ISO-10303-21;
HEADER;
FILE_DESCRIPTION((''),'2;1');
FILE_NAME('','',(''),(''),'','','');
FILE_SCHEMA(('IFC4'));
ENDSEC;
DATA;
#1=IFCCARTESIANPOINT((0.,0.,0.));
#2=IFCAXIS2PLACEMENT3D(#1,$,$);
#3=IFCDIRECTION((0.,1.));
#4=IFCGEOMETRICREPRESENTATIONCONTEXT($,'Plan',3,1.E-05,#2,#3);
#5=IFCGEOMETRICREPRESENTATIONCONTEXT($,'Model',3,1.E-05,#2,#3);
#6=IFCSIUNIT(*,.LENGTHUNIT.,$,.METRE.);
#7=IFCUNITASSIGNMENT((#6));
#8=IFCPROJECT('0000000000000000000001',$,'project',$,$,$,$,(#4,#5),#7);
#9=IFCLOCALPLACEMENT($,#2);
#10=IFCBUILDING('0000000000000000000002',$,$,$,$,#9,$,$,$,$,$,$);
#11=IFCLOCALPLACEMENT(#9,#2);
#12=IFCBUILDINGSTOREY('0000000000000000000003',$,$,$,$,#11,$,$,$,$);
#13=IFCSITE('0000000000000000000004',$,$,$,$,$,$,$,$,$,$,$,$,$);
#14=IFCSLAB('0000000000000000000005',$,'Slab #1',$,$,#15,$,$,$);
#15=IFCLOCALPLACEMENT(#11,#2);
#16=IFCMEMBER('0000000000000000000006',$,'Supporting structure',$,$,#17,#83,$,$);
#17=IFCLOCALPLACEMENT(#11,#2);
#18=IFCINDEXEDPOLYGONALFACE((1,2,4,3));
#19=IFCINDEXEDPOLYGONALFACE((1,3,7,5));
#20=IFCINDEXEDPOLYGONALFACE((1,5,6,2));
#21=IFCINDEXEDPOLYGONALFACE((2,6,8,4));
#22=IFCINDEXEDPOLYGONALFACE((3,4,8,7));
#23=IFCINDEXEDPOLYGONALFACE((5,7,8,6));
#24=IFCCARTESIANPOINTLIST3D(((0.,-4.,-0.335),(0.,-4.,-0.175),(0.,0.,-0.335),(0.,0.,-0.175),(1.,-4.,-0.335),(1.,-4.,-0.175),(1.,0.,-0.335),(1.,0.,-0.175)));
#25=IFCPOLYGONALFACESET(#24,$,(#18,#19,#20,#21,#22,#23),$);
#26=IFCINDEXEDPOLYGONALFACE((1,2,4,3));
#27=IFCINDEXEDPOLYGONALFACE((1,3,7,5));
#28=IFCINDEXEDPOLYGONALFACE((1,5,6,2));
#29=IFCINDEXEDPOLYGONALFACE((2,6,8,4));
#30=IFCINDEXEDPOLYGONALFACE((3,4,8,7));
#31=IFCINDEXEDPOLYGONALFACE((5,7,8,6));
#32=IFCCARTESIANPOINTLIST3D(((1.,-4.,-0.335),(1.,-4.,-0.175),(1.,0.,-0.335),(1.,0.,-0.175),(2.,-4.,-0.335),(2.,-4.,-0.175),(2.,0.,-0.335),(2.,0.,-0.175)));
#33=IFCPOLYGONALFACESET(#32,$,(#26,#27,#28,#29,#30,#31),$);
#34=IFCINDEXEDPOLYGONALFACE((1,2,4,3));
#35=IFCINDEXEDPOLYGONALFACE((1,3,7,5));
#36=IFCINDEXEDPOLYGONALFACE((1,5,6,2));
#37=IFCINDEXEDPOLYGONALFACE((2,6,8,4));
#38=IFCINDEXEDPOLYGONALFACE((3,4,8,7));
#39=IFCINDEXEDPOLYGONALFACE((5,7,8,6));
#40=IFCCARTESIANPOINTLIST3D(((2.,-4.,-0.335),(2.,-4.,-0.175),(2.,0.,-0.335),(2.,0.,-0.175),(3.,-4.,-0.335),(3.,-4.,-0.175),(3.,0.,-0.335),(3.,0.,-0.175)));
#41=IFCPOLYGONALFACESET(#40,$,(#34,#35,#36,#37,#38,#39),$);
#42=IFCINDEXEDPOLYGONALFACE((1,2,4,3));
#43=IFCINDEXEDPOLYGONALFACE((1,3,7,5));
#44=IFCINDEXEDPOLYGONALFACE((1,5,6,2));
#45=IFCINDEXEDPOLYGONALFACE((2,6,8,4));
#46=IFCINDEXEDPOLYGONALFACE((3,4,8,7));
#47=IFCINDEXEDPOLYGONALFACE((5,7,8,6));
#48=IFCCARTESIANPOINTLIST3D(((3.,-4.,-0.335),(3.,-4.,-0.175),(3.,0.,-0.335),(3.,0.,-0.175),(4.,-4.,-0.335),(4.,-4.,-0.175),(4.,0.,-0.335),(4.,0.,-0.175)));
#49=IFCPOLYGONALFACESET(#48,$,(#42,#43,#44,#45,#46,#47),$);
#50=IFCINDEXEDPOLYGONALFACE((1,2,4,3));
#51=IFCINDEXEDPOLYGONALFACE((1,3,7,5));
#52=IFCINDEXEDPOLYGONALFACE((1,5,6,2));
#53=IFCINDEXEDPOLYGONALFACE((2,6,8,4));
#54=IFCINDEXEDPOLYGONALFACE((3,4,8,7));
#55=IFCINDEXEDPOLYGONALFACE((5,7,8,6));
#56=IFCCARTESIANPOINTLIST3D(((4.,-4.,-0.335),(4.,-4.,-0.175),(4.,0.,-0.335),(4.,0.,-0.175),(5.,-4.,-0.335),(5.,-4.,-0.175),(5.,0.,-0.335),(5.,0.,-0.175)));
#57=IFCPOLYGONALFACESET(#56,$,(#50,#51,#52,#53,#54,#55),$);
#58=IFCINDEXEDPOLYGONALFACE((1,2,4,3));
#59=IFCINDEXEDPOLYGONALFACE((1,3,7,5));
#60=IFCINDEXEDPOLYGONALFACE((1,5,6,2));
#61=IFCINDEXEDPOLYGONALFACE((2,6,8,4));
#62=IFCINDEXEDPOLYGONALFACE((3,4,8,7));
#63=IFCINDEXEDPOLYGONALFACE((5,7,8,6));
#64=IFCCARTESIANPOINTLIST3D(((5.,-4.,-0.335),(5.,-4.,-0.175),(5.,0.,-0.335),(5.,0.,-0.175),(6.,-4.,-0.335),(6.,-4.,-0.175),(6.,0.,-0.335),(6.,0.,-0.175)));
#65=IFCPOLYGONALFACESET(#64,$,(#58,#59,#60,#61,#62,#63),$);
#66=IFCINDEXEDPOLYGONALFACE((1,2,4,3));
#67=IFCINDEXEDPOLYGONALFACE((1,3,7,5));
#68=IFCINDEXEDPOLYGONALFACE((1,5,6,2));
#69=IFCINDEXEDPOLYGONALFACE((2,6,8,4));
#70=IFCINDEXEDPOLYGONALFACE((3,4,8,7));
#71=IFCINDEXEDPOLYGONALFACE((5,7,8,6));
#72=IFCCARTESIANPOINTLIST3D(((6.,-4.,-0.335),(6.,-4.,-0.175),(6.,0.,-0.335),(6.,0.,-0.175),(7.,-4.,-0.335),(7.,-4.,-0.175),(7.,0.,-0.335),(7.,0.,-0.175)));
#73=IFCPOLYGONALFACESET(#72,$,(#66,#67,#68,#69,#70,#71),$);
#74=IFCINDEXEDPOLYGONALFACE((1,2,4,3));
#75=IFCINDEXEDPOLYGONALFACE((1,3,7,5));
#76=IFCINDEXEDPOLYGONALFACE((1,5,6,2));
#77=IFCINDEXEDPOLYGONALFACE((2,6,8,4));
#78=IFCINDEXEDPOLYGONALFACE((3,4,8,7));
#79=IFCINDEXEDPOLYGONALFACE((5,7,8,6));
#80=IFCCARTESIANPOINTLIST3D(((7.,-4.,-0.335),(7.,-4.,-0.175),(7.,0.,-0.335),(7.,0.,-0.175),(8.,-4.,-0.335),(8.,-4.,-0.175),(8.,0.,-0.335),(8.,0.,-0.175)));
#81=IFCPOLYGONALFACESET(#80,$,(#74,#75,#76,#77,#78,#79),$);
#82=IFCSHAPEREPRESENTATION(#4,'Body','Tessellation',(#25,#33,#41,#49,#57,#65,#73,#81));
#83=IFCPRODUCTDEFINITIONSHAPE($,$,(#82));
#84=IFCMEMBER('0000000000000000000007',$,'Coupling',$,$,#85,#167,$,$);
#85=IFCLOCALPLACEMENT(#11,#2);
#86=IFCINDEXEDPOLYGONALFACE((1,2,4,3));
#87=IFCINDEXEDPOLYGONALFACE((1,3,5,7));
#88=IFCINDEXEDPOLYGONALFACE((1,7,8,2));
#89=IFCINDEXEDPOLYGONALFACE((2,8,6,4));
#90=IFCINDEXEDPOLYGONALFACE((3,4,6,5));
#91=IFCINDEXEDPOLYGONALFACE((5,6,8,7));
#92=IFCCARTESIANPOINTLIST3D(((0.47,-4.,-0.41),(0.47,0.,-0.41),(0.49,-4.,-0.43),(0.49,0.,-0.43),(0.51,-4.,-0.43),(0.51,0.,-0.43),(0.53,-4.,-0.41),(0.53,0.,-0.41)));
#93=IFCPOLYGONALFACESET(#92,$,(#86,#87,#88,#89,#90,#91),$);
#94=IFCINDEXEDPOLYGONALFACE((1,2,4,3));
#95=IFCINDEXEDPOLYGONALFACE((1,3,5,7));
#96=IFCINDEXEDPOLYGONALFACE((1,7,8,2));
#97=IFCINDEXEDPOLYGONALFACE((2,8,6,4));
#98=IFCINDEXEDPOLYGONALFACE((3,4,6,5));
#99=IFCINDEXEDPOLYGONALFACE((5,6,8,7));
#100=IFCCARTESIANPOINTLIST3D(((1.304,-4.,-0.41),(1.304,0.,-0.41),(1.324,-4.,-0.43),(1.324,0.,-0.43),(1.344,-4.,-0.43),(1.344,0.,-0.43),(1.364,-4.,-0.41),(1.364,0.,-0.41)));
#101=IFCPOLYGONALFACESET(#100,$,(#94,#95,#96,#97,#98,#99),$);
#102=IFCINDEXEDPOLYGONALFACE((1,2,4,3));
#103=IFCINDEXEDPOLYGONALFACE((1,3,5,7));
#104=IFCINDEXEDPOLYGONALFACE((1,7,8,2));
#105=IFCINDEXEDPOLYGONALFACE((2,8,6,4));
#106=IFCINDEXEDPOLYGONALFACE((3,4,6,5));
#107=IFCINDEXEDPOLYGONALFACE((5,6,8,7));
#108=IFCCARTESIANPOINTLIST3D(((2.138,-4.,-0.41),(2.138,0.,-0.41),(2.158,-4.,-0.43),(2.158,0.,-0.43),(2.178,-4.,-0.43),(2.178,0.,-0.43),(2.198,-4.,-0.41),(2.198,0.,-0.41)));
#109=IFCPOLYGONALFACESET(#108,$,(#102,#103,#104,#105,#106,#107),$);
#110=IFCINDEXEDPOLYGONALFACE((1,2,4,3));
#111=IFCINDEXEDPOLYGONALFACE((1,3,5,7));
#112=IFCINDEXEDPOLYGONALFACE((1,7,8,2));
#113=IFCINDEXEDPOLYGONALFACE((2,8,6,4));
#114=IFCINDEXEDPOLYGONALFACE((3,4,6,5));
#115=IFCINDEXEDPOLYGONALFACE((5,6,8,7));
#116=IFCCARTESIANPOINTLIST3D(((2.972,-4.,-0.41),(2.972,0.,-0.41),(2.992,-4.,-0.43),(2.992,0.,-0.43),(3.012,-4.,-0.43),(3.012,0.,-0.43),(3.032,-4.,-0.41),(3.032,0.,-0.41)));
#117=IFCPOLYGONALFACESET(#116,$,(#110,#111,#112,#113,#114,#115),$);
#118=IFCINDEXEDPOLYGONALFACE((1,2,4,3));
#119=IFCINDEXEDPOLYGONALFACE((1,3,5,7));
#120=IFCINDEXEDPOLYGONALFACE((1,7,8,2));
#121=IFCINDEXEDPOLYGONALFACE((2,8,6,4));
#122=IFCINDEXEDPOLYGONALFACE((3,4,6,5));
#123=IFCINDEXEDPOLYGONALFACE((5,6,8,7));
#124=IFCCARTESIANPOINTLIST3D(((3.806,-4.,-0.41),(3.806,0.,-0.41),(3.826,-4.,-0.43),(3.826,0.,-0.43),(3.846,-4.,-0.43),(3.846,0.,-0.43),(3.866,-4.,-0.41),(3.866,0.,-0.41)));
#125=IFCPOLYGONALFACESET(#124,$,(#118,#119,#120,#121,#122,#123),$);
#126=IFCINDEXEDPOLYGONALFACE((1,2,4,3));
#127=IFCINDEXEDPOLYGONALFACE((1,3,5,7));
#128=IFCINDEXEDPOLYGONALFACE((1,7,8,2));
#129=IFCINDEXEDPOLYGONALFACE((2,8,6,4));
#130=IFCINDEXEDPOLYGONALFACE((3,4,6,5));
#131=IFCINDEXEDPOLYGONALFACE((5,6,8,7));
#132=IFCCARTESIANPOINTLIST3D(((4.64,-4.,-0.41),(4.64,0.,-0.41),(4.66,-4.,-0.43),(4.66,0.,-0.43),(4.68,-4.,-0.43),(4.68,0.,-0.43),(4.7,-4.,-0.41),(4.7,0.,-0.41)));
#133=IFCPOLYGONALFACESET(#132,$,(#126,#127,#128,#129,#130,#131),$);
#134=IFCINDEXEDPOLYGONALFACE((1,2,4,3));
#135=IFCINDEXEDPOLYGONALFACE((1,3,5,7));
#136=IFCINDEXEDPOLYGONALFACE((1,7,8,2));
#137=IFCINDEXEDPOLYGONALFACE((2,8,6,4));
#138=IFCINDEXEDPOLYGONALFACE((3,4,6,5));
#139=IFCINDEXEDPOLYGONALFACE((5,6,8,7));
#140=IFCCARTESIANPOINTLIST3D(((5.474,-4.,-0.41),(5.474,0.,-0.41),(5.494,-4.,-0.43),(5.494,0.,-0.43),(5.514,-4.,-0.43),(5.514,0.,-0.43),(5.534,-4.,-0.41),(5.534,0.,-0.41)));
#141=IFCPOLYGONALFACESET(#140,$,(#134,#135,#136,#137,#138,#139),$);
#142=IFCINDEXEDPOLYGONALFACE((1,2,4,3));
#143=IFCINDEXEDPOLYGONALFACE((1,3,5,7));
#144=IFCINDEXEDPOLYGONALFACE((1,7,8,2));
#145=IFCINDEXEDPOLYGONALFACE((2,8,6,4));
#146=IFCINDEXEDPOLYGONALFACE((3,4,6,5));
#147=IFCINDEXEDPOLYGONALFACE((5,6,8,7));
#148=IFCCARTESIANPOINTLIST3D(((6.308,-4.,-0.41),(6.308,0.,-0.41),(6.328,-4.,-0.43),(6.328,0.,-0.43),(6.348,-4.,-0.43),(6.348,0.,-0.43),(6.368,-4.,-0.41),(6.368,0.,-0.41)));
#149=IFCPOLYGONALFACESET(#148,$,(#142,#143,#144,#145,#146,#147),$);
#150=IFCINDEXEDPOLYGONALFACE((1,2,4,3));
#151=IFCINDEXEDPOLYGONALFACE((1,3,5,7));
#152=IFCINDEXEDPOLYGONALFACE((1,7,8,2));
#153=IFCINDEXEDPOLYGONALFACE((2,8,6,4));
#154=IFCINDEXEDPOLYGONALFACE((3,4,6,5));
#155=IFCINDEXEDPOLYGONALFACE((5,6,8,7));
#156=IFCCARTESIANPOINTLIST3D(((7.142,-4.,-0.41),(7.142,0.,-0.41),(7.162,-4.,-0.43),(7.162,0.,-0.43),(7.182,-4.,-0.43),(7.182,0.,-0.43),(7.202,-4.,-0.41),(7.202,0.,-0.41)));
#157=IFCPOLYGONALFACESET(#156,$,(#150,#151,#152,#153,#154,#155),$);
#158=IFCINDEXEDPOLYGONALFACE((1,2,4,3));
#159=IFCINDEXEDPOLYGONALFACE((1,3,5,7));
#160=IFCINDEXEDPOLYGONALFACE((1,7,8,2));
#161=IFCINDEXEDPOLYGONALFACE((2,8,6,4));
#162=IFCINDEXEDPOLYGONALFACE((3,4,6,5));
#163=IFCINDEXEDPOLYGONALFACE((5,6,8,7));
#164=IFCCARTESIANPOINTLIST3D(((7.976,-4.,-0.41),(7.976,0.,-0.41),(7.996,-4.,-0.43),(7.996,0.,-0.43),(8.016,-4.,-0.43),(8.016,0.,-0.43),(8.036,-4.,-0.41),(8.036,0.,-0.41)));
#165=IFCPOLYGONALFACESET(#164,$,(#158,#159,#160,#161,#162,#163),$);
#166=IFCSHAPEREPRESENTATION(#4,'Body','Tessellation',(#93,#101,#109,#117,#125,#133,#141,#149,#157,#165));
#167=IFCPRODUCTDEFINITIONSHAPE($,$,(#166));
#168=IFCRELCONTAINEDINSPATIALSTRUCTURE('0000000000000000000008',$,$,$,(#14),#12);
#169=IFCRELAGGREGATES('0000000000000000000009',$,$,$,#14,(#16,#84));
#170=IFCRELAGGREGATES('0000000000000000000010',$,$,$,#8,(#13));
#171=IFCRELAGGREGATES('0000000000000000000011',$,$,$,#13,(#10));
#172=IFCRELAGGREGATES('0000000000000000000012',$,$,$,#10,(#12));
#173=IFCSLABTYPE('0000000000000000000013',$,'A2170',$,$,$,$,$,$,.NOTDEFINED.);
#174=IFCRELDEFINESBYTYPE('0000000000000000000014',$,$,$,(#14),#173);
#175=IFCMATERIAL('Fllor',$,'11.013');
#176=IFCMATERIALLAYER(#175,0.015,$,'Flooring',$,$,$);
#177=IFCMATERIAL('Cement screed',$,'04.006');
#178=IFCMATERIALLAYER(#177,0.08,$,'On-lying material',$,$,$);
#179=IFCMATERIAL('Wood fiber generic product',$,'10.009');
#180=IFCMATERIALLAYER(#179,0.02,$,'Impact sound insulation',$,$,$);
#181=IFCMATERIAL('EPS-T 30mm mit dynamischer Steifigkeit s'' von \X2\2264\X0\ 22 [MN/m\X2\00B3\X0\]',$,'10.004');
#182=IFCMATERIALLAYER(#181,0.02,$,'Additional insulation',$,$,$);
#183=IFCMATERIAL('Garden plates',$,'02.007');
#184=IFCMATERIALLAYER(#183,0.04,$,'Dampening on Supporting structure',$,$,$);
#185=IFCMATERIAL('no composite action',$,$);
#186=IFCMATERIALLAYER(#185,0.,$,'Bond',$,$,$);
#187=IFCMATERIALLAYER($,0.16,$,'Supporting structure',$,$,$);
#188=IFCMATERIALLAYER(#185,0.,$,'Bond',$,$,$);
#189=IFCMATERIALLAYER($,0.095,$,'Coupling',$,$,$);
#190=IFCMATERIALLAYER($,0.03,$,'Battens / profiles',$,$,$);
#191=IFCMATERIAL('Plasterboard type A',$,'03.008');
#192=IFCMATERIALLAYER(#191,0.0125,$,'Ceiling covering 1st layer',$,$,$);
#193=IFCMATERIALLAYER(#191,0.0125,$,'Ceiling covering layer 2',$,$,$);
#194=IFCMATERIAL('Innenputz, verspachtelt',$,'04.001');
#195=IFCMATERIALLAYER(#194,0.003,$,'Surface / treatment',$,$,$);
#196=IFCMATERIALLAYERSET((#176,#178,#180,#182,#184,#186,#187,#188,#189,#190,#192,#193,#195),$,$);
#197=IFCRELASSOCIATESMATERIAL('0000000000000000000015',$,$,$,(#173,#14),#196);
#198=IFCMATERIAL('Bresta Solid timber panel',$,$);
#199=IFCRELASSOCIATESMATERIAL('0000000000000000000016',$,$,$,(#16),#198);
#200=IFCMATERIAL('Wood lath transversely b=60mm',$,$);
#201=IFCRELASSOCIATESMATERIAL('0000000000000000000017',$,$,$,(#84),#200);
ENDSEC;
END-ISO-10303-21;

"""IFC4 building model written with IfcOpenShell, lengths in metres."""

from ifc_helpers import new_model, si_unit, direction, frame, frame_2d, origin, place, context, project, spatial, polyline, rectangle, outline, extrude, material, layer, layer_set, type_object, element, aggregate, save


model = new_model("IFC4")

# Units and contexts
plan_context = context("Plan", 3, precision=1e-05, world=origin(), true_north=direction((0.0, 1.0)))
model_context = context("Model", 3, precision=1e-05, world=origin(), true_north=direction((0.0, 1.0)))
ifc_project = project(units=[si_unit("LENGTHUNIT", "METRE")], contexts=[plan_context, model_context])

# Site, building, storey
site = spatial("IfcSite", under=ifc_project)
building_placement = place(None, origin())
building = spatial("IfcBuilding", under=site, at=building_placement)
storey_placement = place(building_placement, origin())
storey = spatial("IfcBuildingStorey", under=building, at=storey_placement)

# Slab, members
ifc_material_1 = material(Name="Fllor", Category="11.013")
ifc_layer_1 = layer(ifc_material_1, 0.015, Name="Flooring")
ifc_material_2 = material(Name="Cement screed", Category="04.006")
ifc_layer_2 = layer(ifc_material_2, 0.08, Name="On-lying material")
ifc_material_3 = material(Name="Wood fiber generic product", Category="10.009")
ifc_layer_3 = layer(ifc_material_3, 0.02, Name="Impact sound insulation")
ifc_material_4 = material(Name="EPS-T 30mm mit dynamischer Steifigkeit s' von ≤ 22 [MN/m³]", Category="10.004")
ifc_layer_4 = layer(ifc_material_4, 0.02, Name="Additional insulation")
ifc_material_5 = material(Name="Garden plates", Category="02.007")
ifc_layer_5 = layer(ifc_material_5, 0.04, Name="Dampening on Supporting structure")
ifc_material_6 = material(Name="no composite action")
ifc_layer_6 = layer(ifc_material_6, 0.0, Name="Bond")
ifc_layer_7 = layer(None, 0.16, Name="Supporting structure")
ifc_layer_8 = layer(ifc_material_6, 0.0, Name="Bond")
ifc_layer_9 = layer(None, 0.095, Name="Coupling")
ifc_layer_10 = layer(None, 0.03, Name="Battens / profiles")
ifc_material_7 = material(Name="Plasterboard type A", Category="03.008")
ifc_layer_11 = layer(ifc_material_7, 0.0125, Name="Ceiling covering 1st layer")
ifc_layer_12 = layer(ifc_material_7, 0.0125, Name="Ceiling covering layer 2")
ifc_material_8 = material(Name="Innenputz, verspachtelt", Category="04.001")
ifc_layer_13 = layer(ifc_material_8, 0.003, Name="Surface / treatment")
ifc_layer_set = layer_set([ifc_layer_1, ifc_layer_2, ifc_layer_3, ifc_layer_4, ifc_layer_5, ifc_layer_6, ifc_layer_7, ifc_layer_8, ifc_layer_9, ifc_layer_10, ifc_layer_11, ifc_layer_12, ifc_layer_13])
slab_type = type_object("IfcSlabType", Name="A2170", PredefinedType="NOTDEFINED", material=ifc_layer_set)
slab_placement = place(None, frame((0.0, 0.0, 0.0), z_axis=(0.0, 0.0, -1.0), x_axis=(1.0, 0.0, 0.0)))
slab = element("IfcSlab", 1, at=slab_placement, inside=storey, type_object=slab_type, material=ifc_layer_set, Name="Slab #1")
ifc_material_9 = material(Name="Bresta Solid timber panel")
member_1_placement = place(slab_placement, origin())
member_1 = element("IfcMember", 2, at=member_1_placement, material=ifc_material_9, Name="Supporting structure", context=plan_context, shape_type="SweptSolid", body=[
    extrude(rectangle(XDim=1.0, YDim=0.16, at=frame_2d((0.5, 0.08), x_axis=(1.0, 0.0))), frame((0.0, 4.0, 0.175), z_axis=(0.0, -1.0, 0.0), x_axis=(1.0, 0.0, 0.0)), (0.0, 0.0, 1.0), 4.0),
    extrude(rectangle(XDim=1.0, YDim=0.16, at=frame_2d((0.5, 0.08), x_axis=(1.0, 0.0))), frame((1.0, 4.0, 0.175), z_axis=(0.0, -1.0, 0.0), x_axis=(1.0, 0.0, 0.0)), (0.0, 0.0, 1.0), 4.0),
    extrude(rectangle(XDim=1.0, YDim=0.16, at=frame_2d((0.5, 0.08), x_axis=(1.0, 0.0))), frame((2.0, 4.0, 0.175), z_axis=(0.0, -1.0, 0.0), x_axis=(1.0, 0.0, 0.0)), (0.0, 0.0, 1.0), 4.0),
    extrude(rectangle(XDim=1.0, YDim=0.16, at=frame_2d((0.5, 0.08), x_axis=(1.0, 0.0))), frame((3.0, 4.0, 0.175), z_axis=(0.0, -1.0, 0.0), x_axis=(1.0, 0.0, 0.0)), (0.0, 0.0, 1.0), 4.0),
    extrude(rectangle(XDim=1.0, YDim=0.16, at=frame_2d((0.5, 0.08), x_axis=(1.0, 0.0))), frame((4.0, 4.0, 0.175), z_axis=(0.0, -1.0, 0.0), x_axis=(1.0, 0.0, 0.0)), (0.0, 0.0, 1.0), 4.0),
    extrude(rectangle(XDim=1.0, YDim=0.16, at=frame_2d((0.5, 0.08), x_axis=(1.0, 0.0))), frame((5.0, 4.0, 0.175), z_axis=(0.0, -1.0, 0.0), x_axis=(1.0, 0.0, 0.0)), (0.0, 0.0, 1.0), 4.0),
    extrude(rectangle(XDim=1.0, YDim=0.16, at=frame_2d((0.5, 0.08), x_axis=(1.0, 0.0))), frame((6.0, 4.0, 0.175), z_axis=(0.0, -1.0, 0.0), x_axis=(1.0, 0.0, 0.0)), (0.0, 0.0, 1.0), 4.0),
    extrude(rectangle(XDim=1.0, YDim=0.16, at=frame_2d((0.5, 0.08), x_axis=(1.0, 0.0))), frame((7.0, 4.0, 0.175), z_axis=(0.0, -1.0, 0.0), x_axis=(1.0, 0.0, 0.0)), (0.0, 0.0, 1.0), 4.0),
])
ifc_material_10 = material(Name="Wood lath transversely b=60mm")
member_2_placement = place(slab_placement, origin())
member_2 = element("IfcMember", 3, at=member_2_placement, material=ifc_material_10, Name="Coupling", context=plan_context, shape_type="SweptSolid", body=[
    extrude(outline(polyline([(0.0, 0.0), (0.06, 0.0), (0.04, 0.02), (0.02, 0.02), (0.0, 0.0)])), frame((0.47, 4.0, 0.41), z_axis=(0.0, -1.0, 0.0), x_axis=(1.0, 0.0, 0.0)), (0.0, 0.0, 1.0), 4.0),
    extrude(outline(polyline([(0.0, 0.0), (0.06, 0.0), (0.04, 0.02), (0.02, 0.02), (0.0, 0.0)])), frame((1.304, 4.0, 0.41), z_axis=(0.0, -1.0, 0.0), x_axis=(1.0, 0.0, 0.0)), (0.0, 0.0, 1.0), 4.0),
    extrude(outline(polyline([(0.0, 0.0), (0.06, 0.0), (0.04, 0.02), (0.02, 0.02), (0.0, 0.0)])), frame((2.138, 4.0, 0.41), z_axis=(0.0, -1.0, 0.0), x_axis=(1.0, 0.0, 0.0)), (0.0, 0.0, 1.0), 4.0),
    extrude(outline(polyline([(0.0, 0.0), (0.06, 0.0), (0.04, 0.02), (0.02, 0.02), (0.0, 0.0)])), frame((2.972, 4.0, 0.41), z_axis=(0.0, -1.0, 0.0), x_axis=(1.0, 0.0, 0.0)), (0.0, 0.0, 1.0), 4.0),
    extrude(outline(polyline([(0.0, 0.0), (0.06, 0.0), (0.04, 0.02), (0.02, 0.02), (0.0, 0.0)])), frame((3.806, 4.0, 0.41), z_axis=(0.0, -1.0, 0.0), x_axis=(1.0, 0.0, 0.0)), (0.0, 0.0, 1.0), 4.0),
    extrude(outline(polyline([(0.0, 0.0), (0.06, 0.0), (0.04, 0.02), (0.02, 0.02), (0.0, 0.0)])), frame((4.64, 4.0, 0.41), z_axis=(0.0, -1.0, 0.0), x_axis=(1.0, 0.0, 0.0)), (0.0, 0.0, 1.0), 4.0),
    extrude(outline(polyline([(0.0, 0.0), (0.06, 0.0), (0.04, 0.02), (0.02, 0.02), (0.0, 0.0)])), frame((5.474, 4.0, 0.41), z_axis=(0.0, -1.0, 0.0), x_axis=(1.0, 0.0, 0.0)), (0.0, 0.0, 1.0), 4.0),
    extrude(outline(polyline([(0.0, 0.0), (0.06, 0.0), (0.04, 0.02), (0.02, 0.02), (0.0, 0.0)])), frame((6.308, 4.0, 0.41), z_axis=(0.0, -1.0, 0.0), x_axis=(1.0, 0.0, 0.0)), (0.0, 0.0, 1.0), 4.0),
    extrude(outline(polyline([(0.0, 0.0), (0.06, 0.0), (0.04, 0.02), (0.02, 0.02), (0.0, 0.0)])), frame((7.142, 4.0, 0.41), z_axis=(0.0, -1.0, 0.0), x_axis=(1.0, 0.0, 0.0)), (0.0, 0.0, 1.0), 4.0),
    extrude(outline(polyline([(0.0, 0.0), (0.06, 0.0), (0.04, 0.02), (0.02, 0.02), (0.0, 0.0)])), frame((7.976, 4.0, 0.41), z_axis=(0.0, -1.0, 0.0), x_axis=(1.0, 0.0, 0.0)), (0.0, 0.0, 1.0), 4.0),
])
aggregate(slab, [member_1, member_2])

save(model, "model.ifc")
